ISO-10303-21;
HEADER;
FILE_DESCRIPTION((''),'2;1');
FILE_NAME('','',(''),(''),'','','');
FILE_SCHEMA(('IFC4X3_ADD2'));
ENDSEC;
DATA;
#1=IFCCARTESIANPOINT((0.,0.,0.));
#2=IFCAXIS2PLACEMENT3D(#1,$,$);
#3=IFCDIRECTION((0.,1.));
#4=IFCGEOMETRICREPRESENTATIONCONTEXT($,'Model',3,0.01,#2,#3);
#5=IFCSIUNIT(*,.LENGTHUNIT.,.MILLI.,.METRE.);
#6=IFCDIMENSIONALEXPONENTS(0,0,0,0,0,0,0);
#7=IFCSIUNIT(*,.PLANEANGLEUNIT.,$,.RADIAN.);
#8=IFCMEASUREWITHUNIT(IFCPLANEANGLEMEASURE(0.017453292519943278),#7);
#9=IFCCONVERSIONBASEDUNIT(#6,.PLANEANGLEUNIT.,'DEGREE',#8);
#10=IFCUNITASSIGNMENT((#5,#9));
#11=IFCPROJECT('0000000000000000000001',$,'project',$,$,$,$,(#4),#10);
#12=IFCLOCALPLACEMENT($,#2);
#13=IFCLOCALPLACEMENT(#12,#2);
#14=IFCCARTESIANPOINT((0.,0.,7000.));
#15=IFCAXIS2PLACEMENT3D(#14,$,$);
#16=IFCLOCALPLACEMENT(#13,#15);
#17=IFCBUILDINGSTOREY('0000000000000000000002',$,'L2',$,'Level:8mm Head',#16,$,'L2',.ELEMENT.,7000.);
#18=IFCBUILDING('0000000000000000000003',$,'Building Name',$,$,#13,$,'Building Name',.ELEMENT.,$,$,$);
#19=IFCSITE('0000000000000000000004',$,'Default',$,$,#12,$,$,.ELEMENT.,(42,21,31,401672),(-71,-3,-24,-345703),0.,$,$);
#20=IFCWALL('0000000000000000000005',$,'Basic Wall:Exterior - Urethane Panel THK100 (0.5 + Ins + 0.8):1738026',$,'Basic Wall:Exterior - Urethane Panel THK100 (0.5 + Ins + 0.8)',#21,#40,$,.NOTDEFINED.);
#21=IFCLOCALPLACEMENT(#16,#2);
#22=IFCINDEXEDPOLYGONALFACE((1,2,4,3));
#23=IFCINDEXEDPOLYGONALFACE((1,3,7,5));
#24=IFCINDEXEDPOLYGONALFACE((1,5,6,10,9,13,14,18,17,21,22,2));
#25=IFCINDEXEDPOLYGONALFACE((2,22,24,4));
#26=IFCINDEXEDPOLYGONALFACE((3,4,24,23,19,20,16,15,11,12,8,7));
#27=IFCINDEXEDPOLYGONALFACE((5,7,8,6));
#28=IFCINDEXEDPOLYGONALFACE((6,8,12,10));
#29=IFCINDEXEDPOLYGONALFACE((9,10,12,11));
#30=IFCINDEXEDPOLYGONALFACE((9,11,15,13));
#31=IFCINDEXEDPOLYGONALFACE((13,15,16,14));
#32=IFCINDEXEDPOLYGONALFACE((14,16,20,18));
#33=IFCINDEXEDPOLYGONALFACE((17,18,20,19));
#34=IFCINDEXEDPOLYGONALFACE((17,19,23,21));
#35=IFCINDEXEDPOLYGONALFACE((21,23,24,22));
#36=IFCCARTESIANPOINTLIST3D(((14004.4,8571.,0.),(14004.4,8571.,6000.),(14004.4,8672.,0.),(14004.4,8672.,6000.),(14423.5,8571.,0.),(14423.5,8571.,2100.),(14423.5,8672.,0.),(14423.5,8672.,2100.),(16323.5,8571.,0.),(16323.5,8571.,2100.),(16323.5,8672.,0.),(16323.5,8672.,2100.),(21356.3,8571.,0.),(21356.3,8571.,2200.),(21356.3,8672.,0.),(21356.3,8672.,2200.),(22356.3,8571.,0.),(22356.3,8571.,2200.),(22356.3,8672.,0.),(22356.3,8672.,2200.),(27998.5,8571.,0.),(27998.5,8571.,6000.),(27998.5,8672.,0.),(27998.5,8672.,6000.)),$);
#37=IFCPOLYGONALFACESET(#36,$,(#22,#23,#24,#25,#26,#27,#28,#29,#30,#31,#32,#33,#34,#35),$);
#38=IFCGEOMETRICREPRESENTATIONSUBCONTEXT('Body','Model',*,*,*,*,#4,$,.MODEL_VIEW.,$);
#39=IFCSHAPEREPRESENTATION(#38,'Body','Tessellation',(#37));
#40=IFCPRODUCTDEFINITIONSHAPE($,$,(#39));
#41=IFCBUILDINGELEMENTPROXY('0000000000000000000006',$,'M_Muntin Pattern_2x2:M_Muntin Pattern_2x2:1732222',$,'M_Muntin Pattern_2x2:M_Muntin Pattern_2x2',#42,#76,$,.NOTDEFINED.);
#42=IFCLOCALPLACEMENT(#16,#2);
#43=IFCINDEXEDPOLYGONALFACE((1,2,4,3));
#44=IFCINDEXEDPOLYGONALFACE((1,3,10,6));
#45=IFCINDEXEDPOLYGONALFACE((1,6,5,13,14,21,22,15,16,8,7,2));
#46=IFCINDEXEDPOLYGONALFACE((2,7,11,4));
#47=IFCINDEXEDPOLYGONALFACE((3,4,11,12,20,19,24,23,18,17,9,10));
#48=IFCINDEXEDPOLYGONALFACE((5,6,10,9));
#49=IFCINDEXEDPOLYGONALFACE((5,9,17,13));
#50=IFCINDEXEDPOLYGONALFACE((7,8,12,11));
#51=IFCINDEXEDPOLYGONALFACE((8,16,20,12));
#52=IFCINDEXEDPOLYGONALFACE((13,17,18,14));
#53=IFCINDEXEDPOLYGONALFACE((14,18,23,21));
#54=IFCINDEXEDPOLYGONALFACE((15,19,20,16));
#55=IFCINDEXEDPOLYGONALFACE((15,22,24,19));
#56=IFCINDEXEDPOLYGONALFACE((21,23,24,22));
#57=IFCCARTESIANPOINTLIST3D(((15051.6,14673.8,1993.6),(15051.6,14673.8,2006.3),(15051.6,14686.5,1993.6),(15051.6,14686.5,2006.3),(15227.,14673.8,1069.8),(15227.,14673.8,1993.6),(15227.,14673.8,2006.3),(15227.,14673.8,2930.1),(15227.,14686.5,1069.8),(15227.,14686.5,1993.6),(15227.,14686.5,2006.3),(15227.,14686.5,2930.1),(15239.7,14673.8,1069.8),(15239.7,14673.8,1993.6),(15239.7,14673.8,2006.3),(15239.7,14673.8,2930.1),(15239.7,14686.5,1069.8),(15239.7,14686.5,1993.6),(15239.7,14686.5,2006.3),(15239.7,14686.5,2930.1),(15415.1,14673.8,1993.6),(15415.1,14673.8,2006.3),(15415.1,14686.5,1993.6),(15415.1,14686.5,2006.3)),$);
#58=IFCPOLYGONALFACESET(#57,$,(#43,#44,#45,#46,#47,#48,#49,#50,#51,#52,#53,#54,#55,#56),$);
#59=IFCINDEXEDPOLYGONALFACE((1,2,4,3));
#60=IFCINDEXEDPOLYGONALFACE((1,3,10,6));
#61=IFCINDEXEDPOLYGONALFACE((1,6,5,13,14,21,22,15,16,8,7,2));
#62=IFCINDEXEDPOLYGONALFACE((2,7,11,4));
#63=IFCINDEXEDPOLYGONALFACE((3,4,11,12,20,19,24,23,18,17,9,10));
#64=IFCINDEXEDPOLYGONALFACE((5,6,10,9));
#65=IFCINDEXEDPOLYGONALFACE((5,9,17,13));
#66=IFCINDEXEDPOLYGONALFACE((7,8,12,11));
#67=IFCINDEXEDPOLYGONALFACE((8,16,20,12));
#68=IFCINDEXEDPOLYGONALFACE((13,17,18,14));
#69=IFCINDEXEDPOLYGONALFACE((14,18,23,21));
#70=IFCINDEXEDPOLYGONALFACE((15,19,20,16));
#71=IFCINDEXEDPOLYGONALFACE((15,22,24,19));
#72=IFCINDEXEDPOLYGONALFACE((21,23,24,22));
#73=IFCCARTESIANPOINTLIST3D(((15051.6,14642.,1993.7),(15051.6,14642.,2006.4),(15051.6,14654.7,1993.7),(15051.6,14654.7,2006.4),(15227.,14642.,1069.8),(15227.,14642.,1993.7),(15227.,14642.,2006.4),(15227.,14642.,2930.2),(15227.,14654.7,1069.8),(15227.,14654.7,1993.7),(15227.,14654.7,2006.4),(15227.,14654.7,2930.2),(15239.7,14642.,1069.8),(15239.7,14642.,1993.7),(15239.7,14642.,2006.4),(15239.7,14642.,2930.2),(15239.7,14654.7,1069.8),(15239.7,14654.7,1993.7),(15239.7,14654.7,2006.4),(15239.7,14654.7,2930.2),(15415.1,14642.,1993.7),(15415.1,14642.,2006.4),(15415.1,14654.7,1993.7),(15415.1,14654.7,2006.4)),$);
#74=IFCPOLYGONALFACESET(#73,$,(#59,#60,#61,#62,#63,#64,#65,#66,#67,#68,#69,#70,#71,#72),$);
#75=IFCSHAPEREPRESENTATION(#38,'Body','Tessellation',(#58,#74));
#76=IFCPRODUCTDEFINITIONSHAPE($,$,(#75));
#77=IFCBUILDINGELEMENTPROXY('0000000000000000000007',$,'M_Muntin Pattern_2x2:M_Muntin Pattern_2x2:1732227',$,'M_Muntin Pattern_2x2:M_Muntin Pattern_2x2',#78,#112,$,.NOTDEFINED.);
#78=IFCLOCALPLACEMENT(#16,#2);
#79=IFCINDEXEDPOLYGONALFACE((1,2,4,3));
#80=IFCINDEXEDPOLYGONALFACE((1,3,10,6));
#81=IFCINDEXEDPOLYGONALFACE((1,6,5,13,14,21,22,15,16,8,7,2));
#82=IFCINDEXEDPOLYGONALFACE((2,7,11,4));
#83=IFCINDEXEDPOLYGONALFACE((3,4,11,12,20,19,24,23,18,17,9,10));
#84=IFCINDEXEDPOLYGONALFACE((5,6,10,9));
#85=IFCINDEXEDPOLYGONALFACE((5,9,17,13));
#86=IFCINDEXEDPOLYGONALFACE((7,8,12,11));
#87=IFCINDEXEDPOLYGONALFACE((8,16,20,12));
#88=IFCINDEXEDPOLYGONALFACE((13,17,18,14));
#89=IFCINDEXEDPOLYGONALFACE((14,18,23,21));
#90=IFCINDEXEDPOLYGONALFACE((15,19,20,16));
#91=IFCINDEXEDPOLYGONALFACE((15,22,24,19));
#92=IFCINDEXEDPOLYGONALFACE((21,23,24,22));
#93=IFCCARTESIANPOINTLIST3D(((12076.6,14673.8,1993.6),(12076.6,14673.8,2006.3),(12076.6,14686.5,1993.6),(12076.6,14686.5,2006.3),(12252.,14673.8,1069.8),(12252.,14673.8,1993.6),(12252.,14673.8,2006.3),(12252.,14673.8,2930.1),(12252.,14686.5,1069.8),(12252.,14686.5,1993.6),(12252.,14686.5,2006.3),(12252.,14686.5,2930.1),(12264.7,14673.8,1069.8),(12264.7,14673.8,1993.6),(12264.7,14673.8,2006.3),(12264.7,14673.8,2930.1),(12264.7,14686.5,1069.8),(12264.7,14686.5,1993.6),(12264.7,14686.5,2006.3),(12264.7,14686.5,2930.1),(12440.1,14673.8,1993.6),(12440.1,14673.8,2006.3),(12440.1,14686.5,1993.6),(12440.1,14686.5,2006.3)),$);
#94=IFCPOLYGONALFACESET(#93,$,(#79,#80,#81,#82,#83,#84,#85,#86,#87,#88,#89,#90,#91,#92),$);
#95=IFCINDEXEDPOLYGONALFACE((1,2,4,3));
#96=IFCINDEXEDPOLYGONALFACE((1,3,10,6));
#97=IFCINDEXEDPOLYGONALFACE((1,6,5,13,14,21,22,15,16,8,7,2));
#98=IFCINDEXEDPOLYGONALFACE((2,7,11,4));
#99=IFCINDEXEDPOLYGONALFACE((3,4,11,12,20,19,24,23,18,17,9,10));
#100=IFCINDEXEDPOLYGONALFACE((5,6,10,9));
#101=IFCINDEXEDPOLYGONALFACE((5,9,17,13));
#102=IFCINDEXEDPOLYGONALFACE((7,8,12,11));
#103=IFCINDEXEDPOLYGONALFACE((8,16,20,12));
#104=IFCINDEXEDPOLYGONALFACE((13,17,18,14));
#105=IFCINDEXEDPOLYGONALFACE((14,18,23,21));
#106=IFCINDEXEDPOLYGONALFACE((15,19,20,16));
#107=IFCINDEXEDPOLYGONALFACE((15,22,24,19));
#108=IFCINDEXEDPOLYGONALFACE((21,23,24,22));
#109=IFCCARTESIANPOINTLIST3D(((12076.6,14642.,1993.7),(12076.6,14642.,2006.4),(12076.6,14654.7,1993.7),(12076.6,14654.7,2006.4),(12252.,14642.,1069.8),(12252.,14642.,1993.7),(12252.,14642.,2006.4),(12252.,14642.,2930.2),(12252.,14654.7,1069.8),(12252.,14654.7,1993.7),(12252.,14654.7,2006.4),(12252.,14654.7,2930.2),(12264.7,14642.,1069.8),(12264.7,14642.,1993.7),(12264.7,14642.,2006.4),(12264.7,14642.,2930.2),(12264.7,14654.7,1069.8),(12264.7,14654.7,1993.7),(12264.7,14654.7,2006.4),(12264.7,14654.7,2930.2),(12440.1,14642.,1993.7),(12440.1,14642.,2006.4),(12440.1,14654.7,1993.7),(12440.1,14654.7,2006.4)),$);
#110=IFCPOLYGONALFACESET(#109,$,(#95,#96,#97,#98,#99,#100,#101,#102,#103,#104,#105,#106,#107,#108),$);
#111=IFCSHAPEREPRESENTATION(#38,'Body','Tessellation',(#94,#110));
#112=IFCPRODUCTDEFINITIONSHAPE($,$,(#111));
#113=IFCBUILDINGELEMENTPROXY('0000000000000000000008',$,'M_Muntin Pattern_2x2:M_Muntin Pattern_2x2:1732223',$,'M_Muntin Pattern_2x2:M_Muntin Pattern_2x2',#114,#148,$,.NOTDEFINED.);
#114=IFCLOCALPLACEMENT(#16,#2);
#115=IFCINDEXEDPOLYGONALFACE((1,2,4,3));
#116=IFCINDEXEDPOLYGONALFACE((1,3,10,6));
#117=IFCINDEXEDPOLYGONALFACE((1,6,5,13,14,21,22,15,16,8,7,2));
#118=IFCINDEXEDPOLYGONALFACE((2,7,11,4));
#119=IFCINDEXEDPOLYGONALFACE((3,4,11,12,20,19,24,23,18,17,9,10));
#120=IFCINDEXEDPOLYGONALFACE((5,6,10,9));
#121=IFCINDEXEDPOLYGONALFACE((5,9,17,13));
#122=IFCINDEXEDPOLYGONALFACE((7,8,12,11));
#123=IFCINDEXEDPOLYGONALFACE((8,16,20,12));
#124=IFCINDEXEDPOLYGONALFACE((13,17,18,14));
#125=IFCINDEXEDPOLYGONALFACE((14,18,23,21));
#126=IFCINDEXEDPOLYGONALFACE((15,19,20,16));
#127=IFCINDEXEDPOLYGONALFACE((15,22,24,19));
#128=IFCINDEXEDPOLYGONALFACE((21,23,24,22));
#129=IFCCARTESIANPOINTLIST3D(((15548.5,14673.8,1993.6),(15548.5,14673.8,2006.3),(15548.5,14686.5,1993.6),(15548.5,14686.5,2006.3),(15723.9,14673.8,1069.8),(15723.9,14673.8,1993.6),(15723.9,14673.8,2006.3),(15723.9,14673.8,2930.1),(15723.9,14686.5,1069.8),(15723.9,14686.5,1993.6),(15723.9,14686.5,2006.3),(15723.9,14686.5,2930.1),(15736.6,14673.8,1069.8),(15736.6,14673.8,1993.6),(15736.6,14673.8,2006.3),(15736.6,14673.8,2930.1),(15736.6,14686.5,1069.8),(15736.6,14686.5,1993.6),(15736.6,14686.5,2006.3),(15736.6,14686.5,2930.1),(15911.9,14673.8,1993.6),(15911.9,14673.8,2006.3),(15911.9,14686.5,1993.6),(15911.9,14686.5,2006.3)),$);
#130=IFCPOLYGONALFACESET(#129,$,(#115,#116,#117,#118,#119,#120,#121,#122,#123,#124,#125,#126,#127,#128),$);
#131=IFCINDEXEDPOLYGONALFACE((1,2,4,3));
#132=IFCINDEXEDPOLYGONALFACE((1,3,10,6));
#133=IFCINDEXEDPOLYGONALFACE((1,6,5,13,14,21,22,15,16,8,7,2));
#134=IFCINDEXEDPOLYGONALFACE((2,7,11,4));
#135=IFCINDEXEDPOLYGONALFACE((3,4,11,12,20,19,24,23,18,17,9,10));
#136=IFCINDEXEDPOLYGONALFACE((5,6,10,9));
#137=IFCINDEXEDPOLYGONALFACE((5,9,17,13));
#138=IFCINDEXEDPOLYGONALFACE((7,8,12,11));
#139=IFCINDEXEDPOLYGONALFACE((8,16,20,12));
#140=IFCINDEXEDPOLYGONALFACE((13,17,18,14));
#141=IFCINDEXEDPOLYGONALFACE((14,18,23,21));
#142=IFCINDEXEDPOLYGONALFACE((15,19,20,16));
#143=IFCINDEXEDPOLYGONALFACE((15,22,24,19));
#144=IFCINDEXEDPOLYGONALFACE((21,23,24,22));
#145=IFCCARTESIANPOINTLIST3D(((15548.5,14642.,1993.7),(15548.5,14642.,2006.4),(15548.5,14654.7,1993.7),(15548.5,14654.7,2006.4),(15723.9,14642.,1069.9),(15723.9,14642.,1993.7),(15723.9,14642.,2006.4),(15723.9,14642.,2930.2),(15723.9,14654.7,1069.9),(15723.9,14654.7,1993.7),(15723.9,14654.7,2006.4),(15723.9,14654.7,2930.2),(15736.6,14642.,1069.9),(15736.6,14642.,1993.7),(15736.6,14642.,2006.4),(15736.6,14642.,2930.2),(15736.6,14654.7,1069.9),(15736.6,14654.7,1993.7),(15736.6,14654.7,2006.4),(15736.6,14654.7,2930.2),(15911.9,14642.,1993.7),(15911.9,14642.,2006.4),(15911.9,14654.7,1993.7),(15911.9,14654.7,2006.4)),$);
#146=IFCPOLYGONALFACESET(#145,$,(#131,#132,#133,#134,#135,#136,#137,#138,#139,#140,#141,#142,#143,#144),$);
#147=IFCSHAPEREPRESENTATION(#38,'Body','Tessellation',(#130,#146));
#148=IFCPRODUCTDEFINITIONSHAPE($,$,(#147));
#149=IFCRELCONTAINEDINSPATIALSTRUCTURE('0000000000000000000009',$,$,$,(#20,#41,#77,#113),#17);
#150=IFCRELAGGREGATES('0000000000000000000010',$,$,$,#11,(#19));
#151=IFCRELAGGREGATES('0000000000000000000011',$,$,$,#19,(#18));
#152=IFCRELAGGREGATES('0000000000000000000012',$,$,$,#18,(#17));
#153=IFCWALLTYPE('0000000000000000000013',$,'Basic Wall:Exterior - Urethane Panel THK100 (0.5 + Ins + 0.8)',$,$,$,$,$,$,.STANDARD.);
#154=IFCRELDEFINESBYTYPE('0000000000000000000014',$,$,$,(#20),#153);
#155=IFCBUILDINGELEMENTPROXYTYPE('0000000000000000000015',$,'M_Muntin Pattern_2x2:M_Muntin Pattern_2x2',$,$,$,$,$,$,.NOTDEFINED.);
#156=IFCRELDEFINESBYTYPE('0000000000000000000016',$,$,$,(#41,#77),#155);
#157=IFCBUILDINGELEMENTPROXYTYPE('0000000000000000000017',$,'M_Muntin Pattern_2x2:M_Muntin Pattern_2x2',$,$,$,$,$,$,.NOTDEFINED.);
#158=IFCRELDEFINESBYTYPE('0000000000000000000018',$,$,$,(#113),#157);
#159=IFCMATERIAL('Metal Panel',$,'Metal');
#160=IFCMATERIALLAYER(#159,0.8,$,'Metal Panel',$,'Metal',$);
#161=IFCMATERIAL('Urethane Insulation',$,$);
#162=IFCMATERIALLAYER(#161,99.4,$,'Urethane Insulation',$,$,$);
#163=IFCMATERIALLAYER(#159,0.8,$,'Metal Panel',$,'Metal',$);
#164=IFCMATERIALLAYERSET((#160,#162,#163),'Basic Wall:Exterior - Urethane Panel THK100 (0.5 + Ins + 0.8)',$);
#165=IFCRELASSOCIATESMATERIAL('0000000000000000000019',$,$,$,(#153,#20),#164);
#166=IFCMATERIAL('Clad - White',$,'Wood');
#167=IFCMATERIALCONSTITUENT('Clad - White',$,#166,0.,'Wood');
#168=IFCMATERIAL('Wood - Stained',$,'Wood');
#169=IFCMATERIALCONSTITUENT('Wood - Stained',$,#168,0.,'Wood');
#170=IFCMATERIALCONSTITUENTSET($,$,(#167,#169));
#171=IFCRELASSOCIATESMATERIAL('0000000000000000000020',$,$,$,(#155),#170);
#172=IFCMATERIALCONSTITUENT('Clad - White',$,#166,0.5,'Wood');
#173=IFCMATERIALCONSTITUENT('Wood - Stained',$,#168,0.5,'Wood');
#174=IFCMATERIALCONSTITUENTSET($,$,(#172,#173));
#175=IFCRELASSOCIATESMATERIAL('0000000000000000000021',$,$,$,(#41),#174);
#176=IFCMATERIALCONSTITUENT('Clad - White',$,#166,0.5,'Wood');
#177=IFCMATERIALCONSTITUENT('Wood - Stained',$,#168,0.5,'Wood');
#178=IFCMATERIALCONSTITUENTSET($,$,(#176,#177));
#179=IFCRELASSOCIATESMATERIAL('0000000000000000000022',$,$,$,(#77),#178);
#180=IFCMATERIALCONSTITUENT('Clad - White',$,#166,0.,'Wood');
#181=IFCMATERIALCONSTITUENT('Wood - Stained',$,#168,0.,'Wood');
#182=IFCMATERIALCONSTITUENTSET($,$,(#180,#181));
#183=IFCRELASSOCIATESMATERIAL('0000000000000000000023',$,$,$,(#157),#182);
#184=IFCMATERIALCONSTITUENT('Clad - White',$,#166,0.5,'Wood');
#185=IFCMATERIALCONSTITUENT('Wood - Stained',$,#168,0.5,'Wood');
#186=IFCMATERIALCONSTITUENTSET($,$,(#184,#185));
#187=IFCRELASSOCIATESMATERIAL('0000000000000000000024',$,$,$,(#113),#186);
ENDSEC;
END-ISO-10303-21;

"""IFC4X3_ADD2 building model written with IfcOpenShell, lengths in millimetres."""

from ifc_helpers import new_model, entity, si_unit, converted_unit, direction, frame, frame_2d, origin, place, context, subcontext, project, spatial, polyline, rectangle, outline, extrude, source, transform, mapped, material, layer, layer_set, constituent, constituent_set, type_object, type_shapes, element, save


model = new_model("IFC4X3_ADD2")

# Units and contexts
model_context = context("Model", 3, precision=0.01, world=origin(), true_north=direction((0.0, 1.0)))
body_context = subcontext(model_context, "Body", "Model", "MODEL_VIEW")
ifc_project = project(units=[si_unit("LENGTHUNIT", "METRE", prefix="MILLI"), converted_unit("PLANEANGLEUNIT", "DEGREE", entity("IfcPlaneAngleMeasure", 0.017453292519943278), si_unit("PLANEANGLEUNIT", "RADIAN"), dimensions=[0, 0, 0, 0, 0, 0, 0])], contexts=[model_context])

# Site, building, storey
site_placement = place(None, origin())
site = spatial("IfcSite", under=ifc_project, at=site_placement, Name="Default", CompositionType="ELEMENT", RefLatitude=(42, 21, 31, 401672), RefLongitude=(-71, -3, -24, -345703), RefElevation=0.0)
building_placement = place(site_placement, origin())
building = spatial("IfcBuilding", under=site, at=building_placement, Name="Building Name", LongName="Building Name", CompositionType="ELEMENT")
storey_placement = place(building_placement, frame((0.0, 0.0, 7000.0)))
storey = spatial("IfcBuildingStorey", under=building, at=storey_placement, Name="L2", ObjectType="Level:8mm Head", LongName="L2", CompositionType="ELEMENT", Elevation=7000.0)

# Shared definitions
ifc_material_1 = material(Name="Metal Panel", Category="Metal")
ifc_layer_1 = layer(ifc_material_1, 0.8, Name="Metal Panel", Category="Metal")
ifc_material_2 = material(Name="Urethane Insulation")
ifc_layer_2 = layer(ifc_material_2, 99.4, Name="Urethane Insulation")
ifc_layer_3 = layer(ifc_material_1, 0.8, Name="Metal Panel", Category="Metal")
ifc_layer_set = layer_set([ifc_layer_1, ifc_layer_2, ifc_layer_3], Name="Basic Wall:Exterior - Urethane Panel THK100 (0.5 + Ins + 0.8)")
wall_type = type_object("IfcWallType", Name="Basic Wall:Exterior - Urethane Panel THK100 (0.5 + Ins + 0.8)", PredefinedType="STANDARD", material=ifc_layer_set)

# Wall, openings
wall_1_placement = place(storey_placement, frame((14004.4, 8621.5, 0.0)))
wall_1 = element("IfcWall", 1, at=wall_1_placement, inside=storey, type_object=wall_type, material=ifc_layer_set, Name="Basic Wall:Exterior - Urethane Panel THK100 (0.5 + Ins + 0.8):1738026", ObjectType="Basic Wall:Exterior - Urethane Panel THK100 (0.5 + Ins + 0.8)", PredefinedType="NOTDEFINED", context=body_context, shape_type="SweptSolid", body=[
    extrude(rectangle(XDim=13994.1, YDim=101.0, at=frame_2d((6997.0, 0.0), x_axis=(-1.0, 0.0))), origin(), (0.0, 0.0, 1.0), 6000.0),
])
opening_1_placement = place(wall_1_placement, frame((2319.1, 50.5, 0.0)))
element("IfcOpeningElement", 2, at=opening_1_placement, cuts=wall_1, PredefinedType="OPENING", context=body_context, shape_type="SweptSolid", body=[
    extrude(rectangle(XDim=2100.0, YDim=1900.0, at=frame_2d((1050.0, 950.0), x_axis=(1.0, 0.0))), frame((0.0, 0.0, 0.0), z_axis=(0.0, -1.0, 0.0), x_axis=(0.0, 0.0, 1.0)), (0.0, 0.0, 1.0), 101.0),
])
opening_2_placement = place(wall_1_placement, frame((8351.9, 50.5, 0.0)))
element("IfcOpeningElement", 3, at=opening_2_placement, cuts=wall_1, PredefinedType="OPENING", context=body_context, shape_type="SweptSolid", body=[
    extrude(rectangle(XDim=2200.0, YDim=1000.0, at=frame_2d((1100.0, 500.0), x_axis=(1.0, 0.0))), frame((0.0, 0.0, 0.0), z_axis=(0.0, -1.0, 0.0), x_axis=(0.0, 0.0, 1.0)), (0.0, 0.0, 1.0), 101.0),
])

# Building element proxies
ifc_material_3 = material(Name="Clad - White", Category="Wood")
ifc_constituent_1 = constituent(ifc_material_3, Name="Clad - White", Category="Wood", fraction=0.5)
ifc_material_4 = material(Name="Wood - Stained", Category="Wood")
ifc_constituent_2 = constituent(ifc_material_4, Name="Wood - Stained", Category="Wood", fraction=0.5)
ifc_constituent_set_1 = constituent_set(constituents=[ifc_constituent_1, ifc_constituent_2])
ifc_constituent_3 = constituent(ifc_material_3, Name="Clad - White", Category="Wood", fraction=0.0)
ifc_constituent_4 = constituent(ifc_material_4, Name="Wood - Stained", Category="Wood", fraction=0.0)
ifc_constituent_set_2 = constituent_set(constituents=[ifc_constituent_3, ifc_constituent_4])
building_element_proxy_type_1 = type_object("IfcBuildingElementProxyType", Name="M_Muntin Pattern_2x2:M_Muntin Pattern_2x2", PredefinedType="NOTDEFINED", material=ifc_constituent_set_2)
shared_shape_1 = source(origin(), body_context, "Body", "SweptSolid", [
    extrude(outline(polyline([(6.4, -6.4), (930.1, -6.4), (930.1, 6.3), (6.4, 6.3), (6.4, 181.7), (-6.3, 181.7), (-6.3, 6.3), (-930.2, 6.3), (-930.2, -6.4), (-6.3, -6.4), (-6.3, -181.7), (6.4, -181.7), (6.4, -6.4)])), frame((0.0, 9.5, 930.1), z_axis=(0.0, 1.0, 0.0), x_axis=(0.0, 0.0, 1.0)), (0.0, 0.0, 1.0), 12.7),
    extrude(outline(polyline([(6.4, -6.4), (930.2, -6.4), (930.2, 6.3), (6.4, 6.3), (6.4, 181.7), (-6.3, 181.7), (-6.3, 6.3), (-930.2, 6.3), (-930.2, -6.4), (-6.3, -6.4), (-6.3, -181.7), (6.4, -181.7), (6.4, -6.4)])), frame((0.0, -22.2, 930.2), z_axis=(0.0, 1.0, 0.0), x_axis=(0.0, 0.0, 1.0)), (0.0, 0.0, 1.0), 12.7),
])
type_shapes(building_element_proxy_type_1, [shared_shape_1])
proxy_1_placement = place(storey_placement, frame((15233.4, 14664.3, 1069.8)))
element("IfcBuildingElementProxy", 4, at=proxy_1_placement, inside=storey, type_object=building_element_proxy_type_1, material=ifc_constituent_set_1, Name="M_Muntin Pattern_2x2:M_Muntin Pattern_2x2:1732222", ObjectType="M_Muntin Pattern_2x2:M_Muntin Pattern_2x2", PredefinedType="NOTDEFINED", context=body_context, shape_type="MappedRepresentation", body=[
    mapped(shared_shape_1, transform((0.0, 0.0, 0.0), scale=1.0)),
])
ifc_constituent_5 = constituent(ifc_material_3, Name="Clad - White", Category="Wood", fraction=0.5)
ifc_constituent_6 = constituent(ifc_material_4, Name="Wood - Stained", Category="Wood", fraction=0.5)
ifc_constituent_set_3 = constituent_set(constituents=[ifc_constituent_5, ifc_constituent_6])
proxy_2_placement = place(storey_placement, frame((12258.4, 14664.3, 1069.8)))
element("IfcBuildingElementProxy", 5, at=proxy_2_placement, inside=storey, type_object=building_element_proxy_type_1, material=ifc_constituent_set_3, Name="M_Muntin Pattern_2x2:M_Muntin Pattern_2x2:1732227", ObjectType="M_Muntin Pattern_2x2:M_Muntin Pattern_2x2", PredefinedType="NOTDEFINED", context=body_context, shape_type="MappedRepresentation", body=[
    mapped(shared_shape_1, transform((0.0, 0.0, 0.0), scale=1.0)),
])
ifc_constituent_7 = constituent(ifc_material_3, Name="Clad - White", Category="Wood", fraction=0.5)
ifc_constituent_8 = constituent(ifc_material_4, Name="Wood - Stained", Category="Wood", fraction=0.5)
ifc_constituent_set_4 = constituent_set(constituents=[ifc_constituent_7, ifc_constituent_8])
ifc_constituent_9 = constituent(ifc_material_3, Name="Clad - White", Category="Wood", fraction=0.0)
ifc_constituent_10 = constituent(ifc_material_4, Name="Wood - Stained", Category="Wood", fraction=0.0)
ifc_constituent_set_5 = constituent_set(constituents=[ifc_constituent_9, ifc_constituent_10])
building_element_proxy_type_2 = type_object("IfcBuildingElementProxyType", Name="M_Muntin Pattern_2x2:M_Muntin Pattern_2x2", PredefinedType="NOTDEFINED", material=ifc_constituent_set_5)
shared_shape_2 = source(origin(), body_context, "Body", "SweptSolid", [
    extrude(outline(polyline([(6.4, -6.4), (930.1, -6.4), (930.1, 6.3), (6.4, 6.3), (6.4, 181.7), (-6.3, 181.7), (-6.3, 6.3), (-930.2, 6.3), (-930.2, -6.4), (-6.3, -6.4), (-6.3, -181.7), (6.4, -181.7), (6.4, -6.4)])), frame((0.0, -22.2, 930.1), z_axis=(0.0, 1.0, 0.0), x_axis=(0.0, 0.0, 1.0)), (0.0, 0.0, 1.0), 12.7),
    extrude(outline(polyline([(6.4, -6.4), (930.2, -6.4), (930.2, 6.3), (6.4, 6.3), (6.4, 181.7), (-6.3, 181.7), (-6.3, 6.3), (-930.2, 6.3), (-930.2, -6.4), (-6.3, -6.4), (-6.3, -181.7), (6.4, -181.7), (6.4, -6.4)])), frame((0.0, 9.5, 930.2), z_axis=(0.0, 1.0, 0.0), x_axis=(0.0, 0.0, 1.0)), (0.0, 0.0, 1.0), 12.7),
])
type_shapes(building_element_proxy_type_2, [shared_shape_2])
proxy_3_placement = place(storey_placement, frame((15730.2, 14664.3, 1069.9), z_axis=(0.0, 0.0, 1.0), x_axis=(-1.0, 0.0, 0.0)))
element("IfcBuildingElementProxy", 6, at=proxy_3_placement, inside=storey, type_object=building_element_proxy_type_2, material=ifc_constituent_set_4, Name="M_Muntin Pattern_2x2:M_Muntin Pattern_2x2:1732223", ObjectType="M_Muntin Pattern_2x2:M_Muntin Pattern_2x2", PredefinedType="NOTDEFINED", context=body_context, shape_type="MappedRepresentation", body=[
    mapped(shared_shape_2, transform((0.0, 0.0, 0.0), scale=1.0)),
])

save(model, "model.ifc")
